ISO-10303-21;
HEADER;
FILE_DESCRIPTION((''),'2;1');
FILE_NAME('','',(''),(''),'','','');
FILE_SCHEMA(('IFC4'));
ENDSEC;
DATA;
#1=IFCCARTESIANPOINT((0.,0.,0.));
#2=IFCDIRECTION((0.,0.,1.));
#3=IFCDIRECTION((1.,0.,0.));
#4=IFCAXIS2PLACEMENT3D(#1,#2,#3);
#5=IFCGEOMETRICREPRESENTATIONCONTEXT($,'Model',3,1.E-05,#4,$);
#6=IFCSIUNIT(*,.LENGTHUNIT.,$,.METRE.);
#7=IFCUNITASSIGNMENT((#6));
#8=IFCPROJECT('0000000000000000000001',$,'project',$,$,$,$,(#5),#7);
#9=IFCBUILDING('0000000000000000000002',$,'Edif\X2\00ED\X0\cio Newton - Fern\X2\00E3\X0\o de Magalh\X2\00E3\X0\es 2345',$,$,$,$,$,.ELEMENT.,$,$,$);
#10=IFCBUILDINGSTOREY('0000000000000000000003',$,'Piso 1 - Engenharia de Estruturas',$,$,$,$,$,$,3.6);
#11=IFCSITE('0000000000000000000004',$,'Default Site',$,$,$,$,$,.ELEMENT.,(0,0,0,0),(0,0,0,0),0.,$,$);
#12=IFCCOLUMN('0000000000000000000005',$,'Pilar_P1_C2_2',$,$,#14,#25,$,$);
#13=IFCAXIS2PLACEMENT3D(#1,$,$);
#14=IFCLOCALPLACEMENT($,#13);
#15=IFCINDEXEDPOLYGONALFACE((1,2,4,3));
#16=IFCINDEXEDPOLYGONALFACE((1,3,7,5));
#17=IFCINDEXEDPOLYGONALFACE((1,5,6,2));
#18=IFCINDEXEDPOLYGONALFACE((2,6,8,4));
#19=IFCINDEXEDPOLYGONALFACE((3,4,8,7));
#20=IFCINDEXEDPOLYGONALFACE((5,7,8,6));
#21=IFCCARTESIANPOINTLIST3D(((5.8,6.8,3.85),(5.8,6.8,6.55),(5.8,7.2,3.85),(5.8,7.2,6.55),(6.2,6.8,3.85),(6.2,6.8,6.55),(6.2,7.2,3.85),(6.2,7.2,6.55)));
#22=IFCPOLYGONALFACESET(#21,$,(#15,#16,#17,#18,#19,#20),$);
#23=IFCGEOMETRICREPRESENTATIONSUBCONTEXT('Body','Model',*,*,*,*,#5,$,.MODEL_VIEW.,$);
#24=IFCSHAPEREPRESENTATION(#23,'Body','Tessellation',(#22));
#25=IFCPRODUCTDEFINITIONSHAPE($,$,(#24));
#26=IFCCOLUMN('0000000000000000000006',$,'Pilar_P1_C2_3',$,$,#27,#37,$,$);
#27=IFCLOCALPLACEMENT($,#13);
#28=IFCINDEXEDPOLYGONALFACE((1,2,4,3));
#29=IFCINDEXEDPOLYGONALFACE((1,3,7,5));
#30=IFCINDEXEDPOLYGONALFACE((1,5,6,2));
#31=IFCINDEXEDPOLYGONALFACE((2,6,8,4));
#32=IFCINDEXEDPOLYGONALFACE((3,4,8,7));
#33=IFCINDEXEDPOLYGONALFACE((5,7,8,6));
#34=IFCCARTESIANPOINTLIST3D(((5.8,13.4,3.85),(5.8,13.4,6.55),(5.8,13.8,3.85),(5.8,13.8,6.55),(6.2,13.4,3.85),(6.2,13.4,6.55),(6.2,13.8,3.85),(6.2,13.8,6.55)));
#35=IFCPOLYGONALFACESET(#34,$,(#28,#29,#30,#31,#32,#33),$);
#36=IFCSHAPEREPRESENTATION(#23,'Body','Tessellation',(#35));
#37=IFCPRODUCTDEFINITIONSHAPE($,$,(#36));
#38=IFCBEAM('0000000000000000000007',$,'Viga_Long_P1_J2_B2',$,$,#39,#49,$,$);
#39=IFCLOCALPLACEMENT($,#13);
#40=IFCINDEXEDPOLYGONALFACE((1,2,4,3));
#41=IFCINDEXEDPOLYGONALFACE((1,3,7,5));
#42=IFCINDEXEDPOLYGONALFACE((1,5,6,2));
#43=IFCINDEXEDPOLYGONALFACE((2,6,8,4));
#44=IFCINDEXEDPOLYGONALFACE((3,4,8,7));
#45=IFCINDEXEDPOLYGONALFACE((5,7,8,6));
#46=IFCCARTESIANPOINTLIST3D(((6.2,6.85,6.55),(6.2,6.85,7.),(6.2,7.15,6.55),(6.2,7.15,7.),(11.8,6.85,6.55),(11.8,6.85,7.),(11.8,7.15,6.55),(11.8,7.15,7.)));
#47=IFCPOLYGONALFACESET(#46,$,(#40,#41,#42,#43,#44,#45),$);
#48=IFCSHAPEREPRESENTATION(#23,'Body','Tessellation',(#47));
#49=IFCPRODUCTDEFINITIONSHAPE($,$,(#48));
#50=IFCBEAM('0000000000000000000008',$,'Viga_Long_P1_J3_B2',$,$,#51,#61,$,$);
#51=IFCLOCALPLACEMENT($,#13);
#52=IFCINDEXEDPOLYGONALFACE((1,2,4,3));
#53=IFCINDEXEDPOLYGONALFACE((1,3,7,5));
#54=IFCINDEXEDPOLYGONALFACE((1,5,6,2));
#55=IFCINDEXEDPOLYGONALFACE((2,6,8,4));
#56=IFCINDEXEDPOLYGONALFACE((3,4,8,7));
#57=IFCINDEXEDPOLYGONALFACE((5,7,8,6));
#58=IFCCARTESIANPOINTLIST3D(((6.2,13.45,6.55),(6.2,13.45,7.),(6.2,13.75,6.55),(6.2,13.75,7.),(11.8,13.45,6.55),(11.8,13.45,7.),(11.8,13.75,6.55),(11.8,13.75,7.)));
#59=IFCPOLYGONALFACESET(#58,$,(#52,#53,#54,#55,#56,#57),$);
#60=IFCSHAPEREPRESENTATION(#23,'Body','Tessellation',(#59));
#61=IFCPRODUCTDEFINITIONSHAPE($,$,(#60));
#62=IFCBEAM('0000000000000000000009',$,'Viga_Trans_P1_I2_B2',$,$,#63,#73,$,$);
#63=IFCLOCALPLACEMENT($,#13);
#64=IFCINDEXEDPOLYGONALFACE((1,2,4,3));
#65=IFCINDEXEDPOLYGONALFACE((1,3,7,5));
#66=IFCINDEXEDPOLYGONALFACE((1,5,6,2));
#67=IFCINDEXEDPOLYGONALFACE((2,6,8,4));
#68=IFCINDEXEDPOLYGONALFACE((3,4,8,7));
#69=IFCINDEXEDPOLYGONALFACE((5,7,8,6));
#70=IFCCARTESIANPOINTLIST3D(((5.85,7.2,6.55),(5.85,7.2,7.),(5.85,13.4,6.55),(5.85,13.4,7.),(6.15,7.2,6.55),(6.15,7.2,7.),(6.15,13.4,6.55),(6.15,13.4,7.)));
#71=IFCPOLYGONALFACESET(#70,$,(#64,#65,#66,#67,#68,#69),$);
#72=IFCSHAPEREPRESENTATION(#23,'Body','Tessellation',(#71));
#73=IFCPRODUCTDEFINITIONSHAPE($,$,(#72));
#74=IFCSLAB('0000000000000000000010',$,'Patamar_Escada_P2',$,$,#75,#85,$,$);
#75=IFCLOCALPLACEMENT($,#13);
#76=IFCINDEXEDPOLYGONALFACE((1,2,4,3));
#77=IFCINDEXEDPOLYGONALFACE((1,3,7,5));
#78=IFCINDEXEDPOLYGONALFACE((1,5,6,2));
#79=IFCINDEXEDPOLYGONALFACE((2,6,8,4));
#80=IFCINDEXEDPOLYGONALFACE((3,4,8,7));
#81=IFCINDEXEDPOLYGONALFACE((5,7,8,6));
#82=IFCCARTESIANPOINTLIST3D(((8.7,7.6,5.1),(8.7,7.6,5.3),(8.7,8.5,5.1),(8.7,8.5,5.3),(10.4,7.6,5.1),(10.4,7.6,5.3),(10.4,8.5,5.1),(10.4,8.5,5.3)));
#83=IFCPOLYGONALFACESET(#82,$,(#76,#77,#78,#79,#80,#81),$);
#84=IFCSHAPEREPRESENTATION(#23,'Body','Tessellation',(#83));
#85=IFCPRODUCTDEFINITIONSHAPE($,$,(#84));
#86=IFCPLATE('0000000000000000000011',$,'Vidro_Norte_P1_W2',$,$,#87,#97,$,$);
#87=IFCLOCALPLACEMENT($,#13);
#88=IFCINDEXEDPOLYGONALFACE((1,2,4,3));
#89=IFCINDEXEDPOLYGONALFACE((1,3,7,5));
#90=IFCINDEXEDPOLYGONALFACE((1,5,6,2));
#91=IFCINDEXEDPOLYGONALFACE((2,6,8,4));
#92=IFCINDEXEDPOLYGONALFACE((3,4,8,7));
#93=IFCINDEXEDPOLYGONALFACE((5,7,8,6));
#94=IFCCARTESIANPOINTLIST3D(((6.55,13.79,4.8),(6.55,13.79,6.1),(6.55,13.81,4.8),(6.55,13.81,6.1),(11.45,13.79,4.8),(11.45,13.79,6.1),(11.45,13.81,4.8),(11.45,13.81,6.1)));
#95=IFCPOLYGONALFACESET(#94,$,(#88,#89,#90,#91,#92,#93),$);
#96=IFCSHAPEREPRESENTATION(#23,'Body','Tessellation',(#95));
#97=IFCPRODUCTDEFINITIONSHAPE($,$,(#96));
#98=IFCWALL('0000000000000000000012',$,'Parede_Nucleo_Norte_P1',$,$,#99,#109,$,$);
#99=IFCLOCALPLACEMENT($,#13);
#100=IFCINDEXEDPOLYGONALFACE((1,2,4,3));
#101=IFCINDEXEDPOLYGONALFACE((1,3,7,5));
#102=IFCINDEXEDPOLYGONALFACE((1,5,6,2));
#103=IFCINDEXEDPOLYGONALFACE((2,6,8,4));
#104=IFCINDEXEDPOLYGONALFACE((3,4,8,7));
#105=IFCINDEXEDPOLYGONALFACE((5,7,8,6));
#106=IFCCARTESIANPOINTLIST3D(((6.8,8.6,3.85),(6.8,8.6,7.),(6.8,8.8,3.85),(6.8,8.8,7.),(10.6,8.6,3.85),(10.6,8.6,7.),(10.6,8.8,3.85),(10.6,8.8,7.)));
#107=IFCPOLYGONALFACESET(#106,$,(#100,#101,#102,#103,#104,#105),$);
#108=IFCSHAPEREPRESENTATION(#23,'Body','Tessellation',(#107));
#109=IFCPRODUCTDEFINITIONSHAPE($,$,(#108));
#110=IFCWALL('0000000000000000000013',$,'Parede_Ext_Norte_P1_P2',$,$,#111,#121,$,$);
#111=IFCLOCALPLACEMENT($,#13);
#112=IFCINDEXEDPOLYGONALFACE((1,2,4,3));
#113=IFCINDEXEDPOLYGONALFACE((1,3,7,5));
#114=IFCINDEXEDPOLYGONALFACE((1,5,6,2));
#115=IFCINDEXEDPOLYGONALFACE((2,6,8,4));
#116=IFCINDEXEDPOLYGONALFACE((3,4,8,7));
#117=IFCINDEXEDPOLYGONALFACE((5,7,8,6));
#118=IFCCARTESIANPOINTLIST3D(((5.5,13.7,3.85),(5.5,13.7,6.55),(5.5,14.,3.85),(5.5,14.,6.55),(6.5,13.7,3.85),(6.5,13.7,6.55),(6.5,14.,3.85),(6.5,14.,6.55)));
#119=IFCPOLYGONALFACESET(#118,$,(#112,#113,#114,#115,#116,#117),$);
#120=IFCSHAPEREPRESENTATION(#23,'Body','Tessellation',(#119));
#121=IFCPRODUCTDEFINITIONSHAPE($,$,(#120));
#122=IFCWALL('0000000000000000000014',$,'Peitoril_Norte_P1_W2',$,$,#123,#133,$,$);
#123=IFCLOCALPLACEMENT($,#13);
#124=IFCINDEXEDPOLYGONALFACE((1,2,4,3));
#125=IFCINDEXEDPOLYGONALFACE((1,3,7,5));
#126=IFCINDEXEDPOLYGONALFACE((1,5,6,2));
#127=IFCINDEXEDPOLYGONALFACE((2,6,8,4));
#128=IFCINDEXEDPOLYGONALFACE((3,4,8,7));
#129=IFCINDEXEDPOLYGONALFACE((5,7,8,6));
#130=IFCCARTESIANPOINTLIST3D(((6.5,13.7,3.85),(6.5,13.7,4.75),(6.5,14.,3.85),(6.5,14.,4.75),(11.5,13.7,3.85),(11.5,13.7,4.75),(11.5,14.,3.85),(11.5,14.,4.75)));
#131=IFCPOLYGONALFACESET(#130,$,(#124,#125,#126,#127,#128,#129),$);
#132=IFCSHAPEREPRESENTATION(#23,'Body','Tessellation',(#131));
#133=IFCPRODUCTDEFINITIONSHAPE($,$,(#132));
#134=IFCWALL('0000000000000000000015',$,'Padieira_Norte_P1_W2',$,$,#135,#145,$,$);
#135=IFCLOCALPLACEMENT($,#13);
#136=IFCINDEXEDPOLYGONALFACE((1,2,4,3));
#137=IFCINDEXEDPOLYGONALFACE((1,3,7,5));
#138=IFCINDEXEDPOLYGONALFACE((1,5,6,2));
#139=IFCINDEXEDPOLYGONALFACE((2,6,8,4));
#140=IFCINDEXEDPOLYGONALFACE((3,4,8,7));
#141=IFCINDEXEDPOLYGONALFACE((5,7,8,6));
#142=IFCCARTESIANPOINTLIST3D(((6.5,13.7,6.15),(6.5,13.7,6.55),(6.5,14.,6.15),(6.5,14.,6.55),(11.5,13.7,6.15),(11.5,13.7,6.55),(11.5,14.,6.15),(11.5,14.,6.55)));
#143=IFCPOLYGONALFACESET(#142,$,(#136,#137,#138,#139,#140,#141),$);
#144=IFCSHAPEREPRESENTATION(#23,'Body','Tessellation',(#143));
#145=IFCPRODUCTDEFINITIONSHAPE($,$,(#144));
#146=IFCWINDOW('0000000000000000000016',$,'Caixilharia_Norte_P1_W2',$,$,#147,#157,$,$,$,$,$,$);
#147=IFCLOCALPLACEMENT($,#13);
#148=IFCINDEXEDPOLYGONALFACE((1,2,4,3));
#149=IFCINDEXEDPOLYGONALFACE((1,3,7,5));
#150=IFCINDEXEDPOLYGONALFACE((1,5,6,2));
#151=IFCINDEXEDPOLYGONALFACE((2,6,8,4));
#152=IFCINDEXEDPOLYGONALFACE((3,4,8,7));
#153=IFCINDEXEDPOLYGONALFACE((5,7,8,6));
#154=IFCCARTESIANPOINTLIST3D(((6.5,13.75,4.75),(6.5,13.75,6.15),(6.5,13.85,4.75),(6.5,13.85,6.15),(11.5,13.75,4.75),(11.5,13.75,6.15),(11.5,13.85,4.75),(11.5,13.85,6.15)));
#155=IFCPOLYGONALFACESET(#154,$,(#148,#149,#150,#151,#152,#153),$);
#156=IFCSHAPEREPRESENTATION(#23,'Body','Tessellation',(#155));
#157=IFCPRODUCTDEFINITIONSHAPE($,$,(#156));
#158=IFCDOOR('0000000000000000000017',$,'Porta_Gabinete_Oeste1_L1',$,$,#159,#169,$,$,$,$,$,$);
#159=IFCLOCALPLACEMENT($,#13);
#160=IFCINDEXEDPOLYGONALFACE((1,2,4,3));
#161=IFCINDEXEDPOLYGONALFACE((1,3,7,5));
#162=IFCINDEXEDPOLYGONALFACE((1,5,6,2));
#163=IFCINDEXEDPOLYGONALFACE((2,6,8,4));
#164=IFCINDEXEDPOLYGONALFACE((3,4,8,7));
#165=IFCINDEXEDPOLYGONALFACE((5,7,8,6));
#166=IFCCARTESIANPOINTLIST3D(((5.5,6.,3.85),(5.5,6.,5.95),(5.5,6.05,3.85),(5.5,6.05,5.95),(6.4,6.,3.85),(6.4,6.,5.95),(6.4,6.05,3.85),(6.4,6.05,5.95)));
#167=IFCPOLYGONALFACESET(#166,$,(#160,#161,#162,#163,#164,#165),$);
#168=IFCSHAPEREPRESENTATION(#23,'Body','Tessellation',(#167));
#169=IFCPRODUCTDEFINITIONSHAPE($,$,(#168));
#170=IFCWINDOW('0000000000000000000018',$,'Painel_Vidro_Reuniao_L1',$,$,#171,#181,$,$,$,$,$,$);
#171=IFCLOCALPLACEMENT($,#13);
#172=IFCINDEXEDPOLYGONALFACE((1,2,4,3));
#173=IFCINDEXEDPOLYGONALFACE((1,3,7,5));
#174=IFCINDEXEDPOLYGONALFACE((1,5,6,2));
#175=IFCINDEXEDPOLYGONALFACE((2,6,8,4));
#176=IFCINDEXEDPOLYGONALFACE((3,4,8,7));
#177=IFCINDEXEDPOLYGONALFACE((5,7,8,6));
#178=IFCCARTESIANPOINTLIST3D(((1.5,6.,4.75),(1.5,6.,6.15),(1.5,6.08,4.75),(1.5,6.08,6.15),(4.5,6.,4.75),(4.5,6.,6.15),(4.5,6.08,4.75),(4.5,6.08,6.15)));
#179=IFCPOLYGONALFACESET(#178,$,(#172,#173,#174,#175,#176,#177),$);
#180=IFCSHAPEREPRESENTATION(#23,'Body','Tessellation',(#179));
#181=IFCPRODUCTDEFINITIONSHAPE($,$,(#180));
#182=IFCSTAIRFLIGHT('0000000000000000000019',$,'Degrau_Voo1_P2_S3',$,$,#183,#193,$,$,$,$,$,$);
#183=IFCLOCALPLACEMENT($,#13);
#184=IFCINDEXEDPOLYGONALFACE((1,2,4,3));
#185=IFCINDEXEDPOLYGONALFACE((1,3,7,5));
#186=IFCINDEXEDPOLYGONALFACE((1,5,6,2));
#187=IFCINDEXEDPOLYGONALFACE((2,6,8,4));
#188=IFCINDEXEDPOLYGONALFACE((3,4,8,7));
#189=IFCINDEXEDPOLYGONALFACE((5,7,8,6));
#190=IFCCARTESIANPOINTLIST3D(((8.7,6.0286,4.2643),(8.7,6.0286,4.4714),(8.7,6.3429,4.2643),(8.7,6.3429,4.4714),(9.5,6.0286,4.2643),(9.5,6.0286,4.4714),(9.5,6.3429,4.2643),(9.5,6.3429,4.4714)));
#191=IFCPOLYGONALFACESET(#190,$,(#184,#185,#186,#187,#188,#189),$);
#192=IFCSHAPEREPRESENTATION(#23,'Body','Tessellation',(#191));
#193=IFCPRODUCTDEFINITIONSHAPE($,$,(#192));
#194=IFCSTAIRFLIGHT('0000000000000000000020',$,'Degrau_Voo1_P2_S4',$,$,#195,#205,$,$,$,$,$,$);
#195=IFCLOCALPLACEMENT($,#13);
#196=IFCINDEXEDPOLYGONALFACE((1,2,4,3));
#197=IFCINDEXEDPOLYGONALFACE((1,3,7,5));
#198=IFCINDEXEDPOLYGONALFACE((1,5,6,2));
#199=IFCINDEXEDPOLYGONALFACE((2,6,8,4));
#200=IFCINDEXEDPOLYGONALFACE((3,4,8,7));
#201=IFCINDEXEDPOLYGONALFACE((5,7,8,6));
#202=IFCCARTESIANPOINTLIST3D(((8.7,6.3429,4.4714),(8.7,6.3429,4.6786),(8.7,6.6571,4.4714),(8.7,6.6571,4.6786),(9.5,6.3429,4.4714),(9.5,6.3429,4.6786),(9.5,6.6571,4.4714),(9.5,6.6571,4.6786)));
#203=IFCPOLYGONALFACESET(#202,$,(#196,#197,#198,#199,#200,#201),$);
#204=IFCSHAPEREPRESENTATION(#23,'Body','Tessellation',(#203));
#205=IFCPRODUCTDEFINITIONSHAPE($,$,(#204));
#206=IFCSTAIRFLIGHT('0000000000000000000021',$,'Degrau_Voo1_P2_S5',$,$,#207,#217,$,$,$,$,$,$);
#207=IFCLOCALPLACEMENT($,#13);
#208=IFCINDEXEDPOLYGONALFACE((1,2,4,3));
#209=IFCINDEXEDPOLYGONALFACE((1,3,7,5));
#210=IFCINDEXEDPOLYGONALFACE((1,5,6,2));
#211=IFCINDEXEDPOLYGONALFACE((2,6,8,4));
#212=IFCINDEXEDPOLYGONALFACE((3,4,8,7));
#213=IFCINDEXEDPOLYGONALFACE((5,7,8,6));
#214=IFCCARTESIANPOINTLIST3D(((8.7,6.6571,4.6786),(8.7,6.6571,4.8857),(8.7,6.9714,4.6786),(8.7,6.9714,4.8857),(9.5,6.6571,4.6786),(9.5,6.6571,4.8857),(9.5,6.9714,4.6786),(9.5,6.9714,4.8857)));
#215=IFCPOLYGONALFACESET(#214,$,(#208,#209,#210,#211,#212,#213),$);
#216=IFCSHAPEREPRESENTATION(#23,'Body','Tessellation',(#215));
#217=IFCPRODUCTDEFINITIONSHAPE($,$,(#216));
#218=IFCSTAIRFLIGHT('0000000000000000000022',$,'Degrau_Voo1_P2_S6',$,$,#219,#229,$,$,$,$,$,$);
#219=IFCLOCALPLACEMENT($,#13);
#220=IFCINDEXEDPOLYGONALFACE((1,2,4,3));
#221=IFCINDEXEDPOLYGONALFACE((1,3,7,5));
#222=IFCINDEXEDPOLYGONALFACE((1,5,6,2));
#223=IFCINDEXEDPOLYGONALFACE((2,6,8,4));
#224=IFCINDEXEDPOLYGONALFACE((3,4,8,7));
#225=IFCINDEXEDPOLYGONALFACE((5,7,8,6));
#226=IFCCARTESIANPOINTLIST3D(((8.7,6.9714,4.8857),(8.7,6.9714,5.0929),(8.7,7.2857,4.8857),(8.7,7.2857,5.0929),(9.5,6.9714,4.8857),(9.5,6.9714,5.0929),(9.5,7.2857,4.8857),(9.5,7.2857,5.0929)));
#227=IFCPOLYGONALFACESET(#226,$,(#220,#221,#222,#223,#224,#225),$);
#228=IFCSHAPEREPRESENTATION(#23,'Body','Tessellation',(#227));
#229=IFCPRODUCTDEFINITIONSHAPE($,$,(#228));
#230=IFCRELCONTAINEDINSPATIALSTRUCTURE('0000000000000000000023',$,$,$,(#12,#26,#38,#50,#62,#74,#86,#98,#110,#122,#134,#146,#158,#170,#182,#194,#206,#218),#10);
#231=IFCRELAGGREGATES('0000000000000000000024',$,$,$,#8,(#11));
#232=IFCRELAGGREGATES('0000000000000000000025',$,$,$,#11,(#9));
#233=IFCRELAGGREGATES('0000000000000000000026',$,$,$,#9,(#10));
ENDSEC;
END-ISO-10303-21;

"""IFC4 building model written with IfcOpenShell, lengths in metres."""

from ifc_helpers import new_model, si_unit, frame, frame_2d, origin_with_axes, place, context, subcontext, project, spatial, rectangle, extrude, element, save


model = new_model("IFC4")

# Units and contexts
model_context = context("Model", 3, precision=1e-05, world=origin_with_axes())
body_context = subcontext(model_context, "Body", "Model", "MODEL_VIEW")
ifc_project = project(units=[si_unit("LENGTHUNIT", "METRE")], contexts=[model_context])

# Site, building, storey
site = spatial("IfcSite", under=ifc_project, Name="Default Site", CompositionType="ELEMENT", RefLatitude=(0, 0, 0, 0), RefLongitude=(0, 0, 0, 0), RefElevation=0.0)
building = spatial("IfcBuilding", under=site, Name="Edifício Newton - Fernão de Magalhães 2345", CompositionType="ELEMENT")
storey = spatial("IfcBuildingStorey", under=building, Name="Piso 1 - Engenharia de Estruturas", Elevation=3.6)

# Columns
for number, where, z_axis, x_axis, name in (
    (1, (5.8, 6.8, 3.85), (0.0, 0.0, 1.0), (1.0, 0.0, 0.0), "Pilar_P1_C2_2"),
    (2, (5.8, 13.4, 3.85), (0.0, 0.0, 1.0), (1.0, 0.0, 0.0), "Pilar_P1_C2_3"),
):
    element("IfcColumn", number, at=place(None, frame(where, z_axis=z_axis, x_axis=x_axis)), inside=storey, Name=name, context=body_context, shape_type="SweptSolid", body=[
        extrude(rectangle(XDim=0.4, YDim=0.4, at=frame_2d((0.2, 0.2))), origin_with_axes(), (0.0, 0.0, 1.0), 2.7),
    ])

# Beams
for number, where, z_axis, x_axis, name in (
    (3, (6.2, 6.85, 6.55), (0.0, 0.0, 1.0), (1.0, 0.0, 0.0), "Viga_Long_P1_J2_B2"),
    (4, (6.2, 13.45, 6.55), (0.0, 0.0, 1.0), (1.0, 0.0, 0.0), "Viga_Long_P1_J3_B2"),
):
    element("IfcBeam", number, at=place(None, frame(where, z_axis=z_axis, x_axis=x_axis)), inside=storey, Name=name, context=body_context, shape_type="SweptSolid", body=[
        extrude(rectangle(XDim=5.6, YDim=0.3, at=frame_2d((2.8, 0.15))), origin_with_axes(), (0.0, 0.0, 1.0), 0.45),
    ])
beam_placement = place(None, frame((5.85, 7.2, 6.55), z_axis=(0.0, 0.0, 1.0), x_axis=(1.0, 0.0, 0.0)))
element("IfcBeam", 5, at=beam_placement, inside=storey, Name="Viga_Trans_P1_I2_B2", context=body_context, shape_type="SweptSolid", body=[
    extrude(rectangle(XDim=0.3, YDim=6.2, at=frame_2d((0.15, 3.1))), origin_with_axes(), (0.0, 0.0, 1.0), 0.45),
])

# Slab
slab_placement = place(None, frame((8.7, 7.6, 5.1), z_axis=(0.0, 0.0, 1.0), x_axis=(1.0, 0.0, 0.0)))
element("IfcSlab", 6, at=slab_placement, inside=storey, Name="Patamar_Escada_P2", context=body_context, shape_type="SweptSolid", body=[
    extrude(rectangle(XDim=1.7, YDim=0.9, at=frame_2d((0.85, 0.45))), origin_with_axes(), (0.0, 0.0, 1.0), 0.2),
])

# Plate
plate_placement = place(None, frame((6.55, 13.79, 4.8), z_axis=(0.0, 0.0, 1.0), x_axis=(1.0, 0.0, 0.0)))
element("IfcPlate", 7, at=plate_placement, inside=storey, Name="Vidro_Norte_P1_W2", context=body_context, shape_type="SweptSolid", body=[
    extrude(rectangle(XDim=4.9, YDim=0.02, at=frame_2d((2.45, 0.01))), origin_with_axes(), (0.0, 0.0, 1.0), 1.3),
])

# Walls
wall_1_placement = place(None, frame((6.8, 8.6, 3.85), z_axis=(0.0, 0.0, 1.0), x_axis=(1.0, 0.0, 0.0)))
element("IfcWall", 8, at=wall_1_placement, inside=storey, Name="Parede_Nucleo_Norte_P1", context=body_context, shape_type="SweptSolid", body=[
    extrude(rectangle(XDim=3.8, YDim=0.2, at=frame_2d((1.9, 0.1))), origin_with_axes(), (0.0, 0.0, 1.0), 3.15),
])
wall_2_placement = place(None, frame((5.5, 13.7, 3.85), z_axis=(0.0, 0.0, 1.0), x_axis=(1.0, 0.0, 0.0)))
element("IfcWall", 9, at=wall_2_placement, inside=storey, Name="Parede_Ext_Norte_P1_P2", context=body_context, shape_type="SweptSolid", body=[
    extrude(rectangle(XDim=1.0, YDim=0.3, at=frame_2d((0.5, 0.15))), origin_with_axes(), (0.0, 0.0, 1.0), 2.7),
])
wall_3_placement = place(None, frame((6.5, 13.7, 3.85), z_axis=(0.0, 0.0, 1.0), x_axis=(1.0, 0.0, 0.0)))
element("IfcWall", 10, at=wall_3_placement, inside=storey, Name="Peitoril_Norte_P1_W2", context=body_context, shape_type="SweptSolid", body=[
    extrude(rectangle(XDim=5.0, YDim=0.3, at=frame_2d((2.5, 0.15))), origin_with_axes(), (0.0, 0.0, 1.0), 0.9),
])
wall_4_placement = place(None, frame((6.5, 13.7, 6.15), z_axis=(0.0, 0.0, 1.0), x_axis=(1.0, 0.0, 0.0)))
element("IfcWall", 11, at=wall_4_placement, inside=storey, Name="Padieira_Norte_P1_W2", context=body_context, shape_type="SweptSolid", body=[
    extrude(rectangle(XDim=5.0, YDim=0.3, at=frame_2d((2.5, 0.15))), origin_with_axes(), (0.0, 0.0, 1.0), 0.4),
])

# Window
window_1_placement = place(None, frame((6.5, 13.75, 4.75), z_axis=(0.0, 0.0, 1.0), x_axis=(1.0, 0.0, 0.0)))
element("IfcWindow", 12, at=window_1_placement, inside=storey, Name="Caixilharia_Norte_P1_W2", context=body_context, shape_type="SweptSolid", body=[
    extrude(rectangle(XDim=5.0, YDim=0.1, at=frame_2d((2.5, 0.05))), origin_with_axes(), (0.0, 0.0, 1.0), 1.4),
])

# Door
door_placement = place(None, frame((5.5, 6.0, 3.85), z_axis=(0.0, 0.0, 1.0), x_axis=(1.0, 0.0, 0.0)))
element("IfcDoor", 13, at=door_placement, inside=storey, Name="Porta_Gabinete_Oeste1_L1", context=body_context, shape_type="SweptSolid", body=[
    extrude(rectangle(XDim=0.9, YDim=0.05, at=frame_2d((0.45, 0.025))), origin_with_axes(), (0.0, 0.0, 1.0), 2.1),
])

# Window
window_2_placement = place(None, frame((1.5, 6.0, 4.75), z_axis=(0.0, 0.0, 1.0), x_axis=(1.0, 0.0, 0.0)))
element("IfcWindow", 14, at=window_2_placement, inside=storey, Name="Painel_Vidro_Reuniao_L1", context=body_context, shape_type="SweptSolid", body=[
    extrude(rectangle(XDim=3.0, YDim=0.08, at=frame_2d((1.5, 0.04))), origin_with_axes(), (0.0, 0.0, 1.0), 1.4),
])

# Stair flights
for number, where, z_axis, x_axis, name in (
    (15, (8.7, 6.0286, 4.2643), (0.0, 0.0, 1.0), (1.0, 0.0, 0.0), "Degrau_Voo1_P2_S3"),
    (16, (8.7, 6.3429, 4.4714), (0.0, 0.0, 1.0), (1.0, 0.0, 0.0), "Degrau_Voo1_P2_S4"),
    (17, (8.7, 6.6571, 4.6786), (0.0, 0.0, 1.0), (1.0, 0.0, 0.0), "Degrau_Voo1_P2_S5"),
    (18, (8.7, 6.9714, 4.8857), (0.0, 0.0, 1.0), (1.0, 0.0, 0.0), "Degrau_Voo1_P2_S6"),
):
    element("IfcStairFlight", number, at=place(None, frame(where, z_axis=z_axis, x_axis=x_axis)), inside=storey, Name=name, context=body_context, shape_type="SweptSolid", body=[
        extrude(rectangle(XDim=0.8, YDim=0.3143, at=frame_2d((0.4, 0.1571))), origin_with_axes(), (0.0, 0.0, 1.0), 0.2071),
    ])

save(model, "model.ifc")
